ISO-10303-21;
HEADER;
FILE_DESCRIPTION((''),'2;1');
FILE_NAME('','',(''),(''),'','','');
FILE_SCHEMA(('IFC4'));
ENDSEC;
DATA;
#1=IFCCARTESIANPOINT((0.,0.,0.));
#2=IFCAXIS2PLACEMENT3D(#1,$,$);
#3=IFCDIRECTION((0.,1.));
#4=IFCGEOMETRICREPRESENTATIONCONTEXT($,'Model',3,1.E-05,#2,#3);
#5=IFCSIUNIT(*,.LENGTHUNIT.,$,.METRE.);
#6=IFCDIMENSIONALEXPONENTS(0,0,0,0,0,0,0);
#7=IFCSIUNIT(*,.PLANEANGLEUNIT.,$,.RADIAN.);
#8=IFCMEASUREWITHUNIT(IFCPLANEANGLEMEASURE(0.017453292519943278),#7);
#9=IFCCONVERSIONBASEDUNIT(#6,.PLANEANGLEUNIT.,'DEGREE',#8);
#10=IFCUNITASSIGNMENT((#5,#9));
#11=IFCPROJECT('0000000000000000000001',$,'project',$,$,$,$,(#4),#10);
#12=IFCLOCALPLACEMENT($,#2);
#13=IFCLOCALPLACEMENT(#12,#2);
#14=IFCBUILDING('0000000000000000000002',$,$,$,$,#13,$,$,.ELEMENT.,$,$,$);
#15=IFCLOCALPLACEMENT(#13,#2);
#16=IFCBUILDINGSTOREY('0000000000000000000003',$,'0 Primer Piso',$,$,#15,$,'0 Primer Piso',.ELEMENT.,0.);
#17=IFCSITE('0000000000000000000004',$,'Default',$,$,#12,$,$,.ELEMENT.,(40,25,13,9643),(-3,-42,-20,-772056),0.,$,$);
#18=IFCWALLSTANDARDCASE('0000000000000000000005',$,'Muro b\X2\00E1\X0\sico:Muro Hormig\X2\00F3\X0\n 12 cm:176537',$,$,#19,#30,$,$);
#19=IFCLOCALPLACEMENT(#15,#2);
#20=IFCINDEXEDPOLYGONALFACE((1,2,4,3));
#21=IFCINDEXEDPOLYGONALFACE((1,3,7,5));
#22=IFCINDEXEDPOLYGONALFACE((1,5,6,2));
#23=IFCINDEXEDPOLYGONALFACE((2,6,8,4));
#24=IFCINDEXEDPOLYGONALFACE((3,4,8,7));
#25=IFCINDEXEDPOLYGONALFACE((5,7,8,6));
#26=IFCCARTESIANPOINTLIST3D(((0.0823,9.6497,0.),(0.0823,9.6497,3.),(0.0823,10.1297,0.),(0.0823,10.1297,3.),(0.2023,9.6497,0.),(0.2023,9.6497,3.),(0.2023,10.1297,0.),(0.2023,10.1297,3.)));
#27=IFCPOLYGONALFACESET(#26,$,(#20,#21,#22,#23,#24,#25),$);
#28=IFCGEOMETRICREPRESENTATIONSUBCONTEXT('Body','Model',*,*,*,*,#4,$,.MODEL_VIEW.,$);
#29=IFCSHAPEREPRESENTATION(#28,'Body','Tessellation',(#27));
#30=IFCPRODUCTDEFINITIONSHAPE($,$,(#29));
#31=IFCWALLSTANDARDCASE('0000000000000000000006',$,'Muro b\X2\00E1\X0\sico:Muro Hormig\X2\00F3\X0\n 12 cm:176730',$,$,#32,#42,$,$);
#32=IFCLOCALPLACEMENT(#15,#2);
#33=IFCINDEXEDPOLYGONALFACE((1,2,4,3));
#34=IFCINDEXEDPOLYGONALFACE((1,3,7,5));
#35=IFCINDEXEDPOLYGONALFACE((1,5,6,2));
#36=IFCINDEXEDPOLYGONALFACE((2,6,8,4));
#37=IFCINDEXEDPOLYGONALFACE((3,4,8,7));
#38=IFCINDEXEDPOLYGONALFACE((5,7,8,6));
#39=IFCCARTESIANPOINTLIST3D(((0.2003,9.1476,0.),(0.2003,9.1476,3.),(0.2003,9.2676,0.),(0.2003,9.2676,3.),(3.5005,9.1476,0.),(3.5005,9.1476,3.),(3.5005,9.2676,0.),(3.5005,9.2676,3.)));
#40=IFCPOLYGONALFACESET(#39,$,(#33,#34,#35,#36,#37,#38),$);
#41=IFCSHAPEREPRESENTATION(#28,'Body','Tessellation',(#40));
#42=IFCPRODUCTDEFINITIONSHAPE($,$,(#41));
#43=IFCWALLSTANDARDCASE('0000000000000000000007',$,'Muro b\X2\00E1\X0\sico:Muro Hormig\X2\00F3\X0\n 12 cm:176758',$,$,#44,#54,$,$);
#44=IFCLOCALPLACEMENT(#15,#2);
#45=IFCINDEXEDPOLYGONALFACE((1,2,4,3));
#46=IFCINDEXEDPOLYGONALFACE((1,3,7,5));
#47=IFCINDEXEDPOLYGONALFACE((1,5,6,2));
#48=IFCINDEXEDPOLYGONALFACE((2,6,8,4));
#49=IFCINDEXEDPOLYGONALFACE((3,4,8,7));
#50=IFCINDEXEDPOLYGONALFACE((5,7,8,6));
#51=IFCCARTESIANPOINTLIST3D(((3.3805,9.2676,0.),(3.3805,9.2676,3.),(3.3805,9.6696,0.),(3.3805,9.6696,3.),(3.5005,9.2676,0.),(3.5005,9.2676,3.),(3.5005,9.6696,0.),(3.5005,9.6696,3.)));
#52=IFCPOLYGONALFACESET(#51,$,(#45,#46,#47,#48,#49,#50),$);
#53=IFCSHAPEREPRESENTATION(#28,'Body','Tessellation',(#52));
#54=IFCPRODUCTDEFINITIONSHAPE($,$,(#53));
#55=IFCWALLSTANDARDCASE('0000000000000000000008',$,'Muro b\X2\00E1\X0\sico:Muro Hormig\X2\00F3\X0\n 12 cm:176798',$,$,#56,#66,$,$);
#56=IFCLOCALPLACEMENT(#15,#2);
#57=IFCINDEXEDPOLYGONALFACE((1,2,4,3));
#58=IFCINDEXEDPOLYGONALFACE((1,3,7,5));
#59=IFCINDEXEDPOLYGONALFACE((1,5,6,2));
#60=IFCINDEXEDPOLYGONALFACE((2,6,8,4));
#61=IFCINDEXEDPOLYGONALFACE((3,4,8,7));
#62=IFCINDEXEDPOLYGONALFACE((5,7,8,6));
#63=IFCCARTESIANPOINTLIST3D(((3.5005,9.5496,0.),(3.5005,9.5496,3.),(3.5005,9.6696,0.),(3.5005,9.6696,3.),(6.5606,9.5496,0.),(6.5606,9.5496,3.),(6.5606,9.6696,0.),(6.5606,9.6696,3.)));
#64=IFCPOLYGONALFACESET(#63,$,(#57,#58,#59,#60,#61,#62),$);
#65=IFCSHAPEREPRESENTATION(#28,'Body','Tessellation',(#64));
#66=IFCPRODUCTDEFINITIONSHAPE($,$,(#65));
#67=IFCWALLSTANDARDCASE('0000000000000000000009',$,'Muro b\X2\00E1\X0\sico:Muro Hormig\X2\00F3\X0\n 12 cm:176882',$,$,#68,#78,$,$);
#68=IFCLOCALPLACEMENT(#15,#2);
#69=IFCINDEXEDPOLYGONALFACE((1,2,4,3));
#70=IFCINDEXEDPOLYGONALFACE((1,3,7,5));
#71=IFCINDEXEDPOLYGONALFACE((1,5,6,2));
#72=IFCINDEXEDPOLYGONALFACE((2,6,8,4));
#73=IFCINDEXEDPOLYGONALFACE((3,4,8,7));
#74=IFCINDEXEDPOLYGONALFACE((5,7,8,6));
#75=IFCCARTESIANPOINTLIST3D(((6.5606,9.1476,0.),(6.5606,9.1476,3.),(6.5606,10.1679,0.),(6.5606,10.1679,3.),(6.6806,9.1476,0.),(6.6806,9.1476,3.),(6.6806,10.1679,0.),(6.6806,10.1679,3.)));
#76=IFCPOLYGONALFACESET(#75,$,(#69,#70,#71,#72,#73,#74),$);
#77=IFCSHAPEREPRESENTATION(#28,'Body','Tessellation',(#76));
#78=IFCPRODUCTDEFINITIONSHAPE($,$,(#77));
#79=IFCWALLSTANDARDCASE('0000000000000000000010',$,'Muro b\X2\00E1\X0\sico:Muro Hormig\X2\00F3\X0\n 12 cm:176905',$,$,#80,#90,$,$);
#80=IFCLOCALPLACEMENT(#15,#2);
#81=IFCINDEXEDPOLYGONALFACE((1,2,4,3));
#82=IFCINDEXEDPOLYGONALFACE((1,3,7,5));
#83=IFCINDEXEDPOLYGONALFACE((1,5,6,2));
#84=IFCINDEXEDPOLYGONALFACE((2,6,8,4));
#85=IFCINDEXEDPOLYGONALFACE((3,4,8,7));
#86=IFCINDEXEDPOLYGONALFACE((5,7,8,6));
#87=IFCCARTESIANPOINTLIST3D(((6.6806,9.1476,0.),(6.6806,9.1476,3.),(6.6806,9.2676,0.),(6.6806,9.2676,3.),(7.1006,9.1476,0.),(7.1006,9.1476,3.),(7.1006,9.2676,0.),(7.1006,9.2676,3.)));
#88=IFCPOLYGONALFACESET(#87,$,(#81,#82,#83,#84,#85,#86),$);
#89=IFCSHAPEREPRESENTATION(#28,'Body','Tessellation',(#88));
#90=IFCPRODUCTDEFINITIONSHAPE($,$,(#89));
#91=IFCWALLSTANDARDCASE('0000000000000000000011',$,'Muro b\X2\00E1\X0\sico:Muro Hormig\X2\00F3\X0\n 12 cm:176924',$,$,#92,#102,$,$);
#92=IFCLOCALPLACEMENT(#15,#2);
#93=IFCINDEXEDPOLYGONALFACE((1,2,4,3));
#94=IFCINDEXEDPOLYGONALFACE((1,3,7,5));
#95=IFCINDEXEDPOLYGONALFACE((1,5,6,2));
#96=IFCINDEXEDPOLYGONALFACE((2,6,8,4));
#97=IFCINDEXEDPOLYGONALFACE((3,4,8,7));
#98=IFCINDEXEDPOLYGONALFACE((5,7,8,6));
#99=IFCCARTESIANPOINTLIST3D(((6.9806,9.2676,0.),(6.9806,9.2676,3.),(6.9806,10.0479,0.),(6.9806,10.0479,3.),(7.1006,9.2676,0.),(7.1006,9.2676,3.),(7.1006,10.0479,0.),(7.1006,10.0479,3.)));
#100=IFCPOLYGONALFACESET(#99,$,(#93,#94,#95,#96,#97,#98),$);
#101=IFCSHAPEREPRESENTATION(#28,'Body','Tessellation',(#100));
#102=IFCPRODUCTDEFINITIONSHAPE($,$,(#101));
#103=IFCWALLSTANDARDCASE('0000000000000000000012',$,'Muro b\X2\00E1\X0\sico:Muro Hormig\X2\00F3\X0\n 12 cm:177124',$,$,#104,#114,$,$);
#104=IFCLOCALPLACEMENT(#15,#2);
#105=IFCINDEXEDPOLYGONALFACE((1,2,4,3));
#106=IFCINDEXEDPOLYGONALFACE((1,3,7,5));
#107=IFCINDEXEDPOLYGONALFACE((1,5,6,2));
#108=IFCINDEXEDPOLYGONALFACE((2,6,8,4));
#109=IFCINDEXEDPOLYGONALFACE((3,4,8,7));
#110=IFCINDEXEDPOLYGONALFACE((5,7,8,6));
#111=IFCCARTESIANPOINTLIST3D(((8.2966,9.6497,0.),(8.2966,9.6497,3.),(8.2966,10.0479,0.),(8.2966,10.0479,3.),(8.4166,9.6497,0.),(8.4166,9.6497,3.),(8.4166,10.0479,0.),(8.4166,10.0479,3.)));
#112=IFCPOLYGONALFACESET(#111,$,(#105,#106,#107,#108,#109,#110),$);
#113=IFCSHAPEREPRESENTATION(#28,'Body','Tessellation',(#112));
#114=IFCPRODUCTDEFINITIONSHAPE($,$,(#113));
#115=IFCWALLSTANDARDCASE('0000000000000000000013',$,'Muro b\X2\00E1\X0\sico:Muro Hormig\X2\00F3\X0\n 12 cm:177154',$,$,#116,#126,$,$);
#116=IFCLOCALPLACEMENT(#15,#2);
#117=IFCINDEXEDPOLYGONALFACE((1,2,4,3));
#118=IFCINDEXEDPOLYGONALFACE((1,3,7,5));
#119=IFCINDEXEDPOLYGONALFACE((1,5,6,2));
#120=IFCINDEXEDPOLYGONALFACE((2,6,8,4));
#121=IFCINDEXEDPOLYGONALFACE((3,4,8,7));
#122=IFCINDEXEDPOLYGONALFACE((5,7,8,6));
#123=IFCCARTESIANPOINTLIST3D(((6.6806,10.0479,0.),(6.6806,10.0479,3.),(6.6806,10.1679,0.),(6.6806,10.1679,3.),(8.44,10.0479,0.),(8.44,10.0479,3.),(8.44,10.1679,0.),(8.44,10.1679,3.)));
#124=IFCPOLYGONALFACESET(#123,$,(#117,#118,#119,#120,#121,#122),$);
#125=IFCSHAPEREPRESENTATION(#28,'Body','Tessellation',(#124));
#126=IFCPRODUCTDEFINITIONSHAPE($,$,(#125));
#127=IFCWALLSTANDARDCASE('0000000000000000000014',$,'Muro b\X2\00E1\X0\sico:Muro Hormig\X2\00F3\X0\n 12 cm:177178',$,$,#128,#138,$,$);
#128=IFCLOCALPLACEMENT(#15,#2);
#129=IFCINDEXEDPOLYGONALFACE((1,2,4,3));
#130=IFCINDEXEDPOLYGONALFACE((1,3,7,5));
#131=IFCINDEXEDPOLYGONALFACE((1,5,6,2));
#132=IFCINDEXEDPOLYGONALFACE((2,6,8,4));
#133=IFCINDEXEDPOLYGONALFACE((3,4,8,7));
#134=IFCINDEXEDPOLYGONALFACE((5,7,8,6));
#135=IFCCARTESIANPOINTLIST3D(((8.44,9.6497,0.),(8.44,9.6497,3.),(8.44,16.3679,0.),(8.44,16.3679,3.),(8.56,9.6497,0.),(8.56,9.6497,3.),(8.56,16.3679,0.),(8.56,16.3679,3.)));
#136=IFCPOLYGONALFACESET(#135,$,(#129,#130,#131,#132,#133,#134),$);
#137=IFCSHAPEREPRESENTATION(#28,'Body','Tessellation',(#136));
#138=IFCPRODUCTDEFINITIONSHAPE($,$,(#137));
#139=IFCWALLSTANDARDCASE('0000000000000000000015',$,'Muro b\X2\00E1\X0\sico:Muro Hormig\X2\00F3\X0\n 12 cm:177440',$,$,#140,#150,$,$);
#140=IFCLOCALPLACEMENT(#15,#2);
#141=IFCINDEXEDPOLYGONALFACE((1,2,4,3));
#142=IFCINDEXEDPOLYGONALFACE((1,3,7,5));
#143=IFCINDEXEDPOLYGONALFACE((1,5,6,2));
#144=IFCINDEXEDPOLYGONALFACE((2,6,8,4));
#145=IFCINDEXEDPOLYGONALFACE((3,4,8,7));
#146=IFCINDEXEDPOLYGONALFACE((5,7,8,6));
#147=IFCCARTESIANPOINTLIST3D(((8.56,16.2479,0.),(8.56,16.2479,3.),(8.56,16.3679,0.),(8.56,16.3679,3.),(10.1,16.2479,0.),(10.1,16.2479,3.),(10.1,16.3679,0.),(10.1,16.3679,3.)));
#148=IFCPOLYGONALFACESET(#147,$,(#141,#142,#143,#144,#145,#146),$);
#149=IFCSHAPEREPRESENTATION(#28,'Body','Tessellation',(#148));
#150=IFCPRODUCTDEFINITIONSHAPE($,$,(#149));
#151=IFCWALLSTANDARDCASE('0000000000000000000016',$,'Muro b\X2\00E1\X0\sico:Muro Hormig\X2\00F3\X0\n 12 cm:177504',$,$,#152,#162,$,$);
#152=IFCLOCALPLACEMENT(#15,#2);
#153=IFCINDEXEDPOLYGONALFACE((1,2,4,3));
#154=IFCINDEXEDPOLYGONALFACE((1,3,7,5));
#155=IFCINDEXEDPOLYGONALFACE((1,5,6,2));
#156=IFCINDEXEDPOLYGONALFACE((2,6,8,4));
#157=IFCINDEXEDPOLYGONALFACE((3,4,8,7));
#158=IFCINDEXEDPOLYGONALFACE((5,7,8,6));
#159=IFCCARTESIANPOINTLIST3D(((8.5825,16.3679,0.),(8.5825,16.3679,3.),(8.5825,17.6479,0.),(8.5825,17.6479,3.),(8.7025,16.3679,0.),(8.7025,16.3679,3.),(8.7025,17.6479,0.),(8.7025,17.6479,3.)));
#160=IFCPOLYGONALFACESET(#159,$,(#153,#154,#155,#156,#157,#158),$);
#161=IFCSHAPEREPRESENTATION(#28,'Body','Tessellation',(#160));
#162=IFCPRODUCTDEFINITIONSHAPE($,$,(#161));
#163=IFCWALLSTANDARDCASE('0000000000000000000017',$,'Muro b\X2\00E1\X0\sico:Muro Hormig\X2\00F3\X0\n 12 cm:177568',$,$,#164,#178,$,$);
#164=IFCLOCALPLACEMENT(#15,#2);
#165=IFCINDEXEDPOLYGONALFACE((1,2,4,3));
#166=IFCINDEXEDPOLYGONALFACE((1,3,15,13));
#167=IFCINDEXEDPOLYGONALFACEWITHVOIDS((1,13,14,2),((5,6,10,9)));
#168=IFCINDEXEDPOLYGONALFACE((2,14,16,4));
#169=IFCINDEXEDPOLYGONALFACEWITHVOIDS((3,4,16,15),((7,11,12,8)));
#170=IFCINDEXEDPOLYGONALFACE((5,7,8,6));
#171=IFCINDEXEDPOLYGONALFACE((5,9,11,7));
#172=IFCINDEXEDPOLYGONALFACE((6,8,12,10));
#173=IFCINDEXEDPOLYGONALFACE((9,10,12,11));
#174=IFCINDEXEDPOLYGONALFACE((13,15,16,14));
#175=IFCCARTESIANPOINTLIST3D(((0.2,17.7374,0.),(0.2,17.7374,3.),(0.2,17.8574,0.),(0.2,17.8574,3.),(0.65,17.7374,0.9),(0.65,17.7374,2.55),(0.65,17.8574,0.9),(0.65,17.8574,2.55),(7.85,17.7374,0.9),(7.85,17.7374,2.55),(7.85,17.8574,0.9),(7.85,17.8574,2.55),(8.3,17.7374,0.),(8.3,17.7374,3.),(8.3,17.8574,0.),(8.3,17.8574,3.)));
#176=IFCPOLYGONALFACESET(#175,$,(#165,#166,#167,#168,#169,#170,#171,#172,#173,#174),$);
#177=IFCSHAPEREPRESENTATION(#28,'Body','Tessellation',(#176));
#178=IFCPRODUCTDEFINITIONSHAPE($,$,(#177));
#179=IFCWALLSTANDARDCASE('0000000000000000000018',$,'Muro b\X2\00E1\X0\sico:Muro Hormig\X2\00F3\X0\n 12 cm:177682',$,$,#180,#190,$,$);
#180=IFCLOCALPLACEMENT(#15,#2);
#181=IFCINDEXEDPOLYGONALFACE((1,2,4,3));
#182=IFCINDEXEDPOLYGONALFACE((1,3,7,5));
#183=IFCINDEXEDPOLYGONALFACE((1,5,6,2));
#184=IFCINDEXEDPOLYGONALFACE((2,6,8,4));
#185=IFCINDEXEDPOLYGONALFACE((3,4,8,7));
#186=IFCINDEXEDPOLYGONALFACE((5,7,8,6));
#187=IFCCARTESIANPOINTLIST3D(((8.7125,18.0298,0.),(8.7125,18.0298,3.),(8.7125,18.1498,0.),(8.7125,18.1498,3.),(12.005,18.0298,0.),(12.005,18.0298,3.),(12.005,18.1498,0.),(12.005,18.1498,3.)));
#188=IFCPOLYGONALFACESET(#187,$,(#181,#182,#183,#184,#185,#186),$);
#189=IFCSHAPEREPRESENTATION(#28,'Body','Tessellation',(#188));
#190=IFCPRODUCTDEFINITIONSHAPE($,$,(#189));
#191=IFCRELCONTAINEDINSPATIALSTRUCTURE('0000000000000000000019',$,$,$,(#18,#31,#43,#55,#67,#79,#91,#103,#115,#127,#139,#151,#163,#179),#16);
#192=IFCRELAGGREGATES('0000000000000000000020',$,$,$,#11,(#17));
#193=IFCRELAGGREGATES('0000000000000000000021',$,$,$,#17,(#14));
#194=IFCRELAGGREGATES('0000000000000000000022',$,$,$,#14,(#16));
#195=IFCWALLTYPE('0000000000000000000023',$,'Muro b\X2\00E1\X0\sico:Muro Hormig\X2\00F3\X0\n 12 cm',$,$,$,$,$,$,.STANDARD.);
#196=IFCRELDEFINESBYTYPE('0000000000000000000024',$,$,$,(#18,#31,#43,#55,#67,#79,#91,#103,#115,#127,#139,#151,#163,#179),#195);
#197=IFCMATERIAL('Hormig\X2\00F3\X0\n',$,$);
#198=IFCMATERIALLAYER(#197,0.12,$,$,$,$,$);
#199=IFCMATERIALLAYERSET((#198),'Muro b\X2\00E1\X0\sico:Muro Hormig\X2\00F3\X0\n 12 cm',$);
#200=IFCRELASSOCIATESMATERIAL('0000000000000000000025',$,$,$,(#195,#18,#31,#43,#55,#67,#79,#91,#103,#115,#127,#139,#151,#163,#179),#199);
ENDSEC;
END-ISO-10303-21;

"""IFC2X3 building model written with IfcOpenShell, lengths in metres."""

from ifc_helpers import new_model, entity, si_unit, converted_unit, direction, frame, frame_2d, origin, place, context, subcontext, project, spatial, rectangle, extrude, material, layer, layer_set, layer_usage, type_object, element, save


model = new_model("IFC2X3")

# Units and contexts
model_context = context("Model", 3, precision=1e-05, world=origin(), true_north=direction((0.0, 1.0)))
body_context = subcontext(model_context, "Body", "Model", "MODEL_VIEW")
ifc_project = project(units=[si_unit("LENGTHUNIT", "METRE"), converted_unit("PLANEANGLEUNIT", "DEGREE", entity("IfcPlaneAngleMeasure", 0.017453292519943278), si_unit("PLANEANGLEUNIT", "RADIAN"), dimensions=[0, 0, 0, 0, 0, 0, 0])], contexts=[model_context])

# Site, building, storey
site_placement = place(None, origin())
site = spatial("IfcSite", under=ifc_project, at=site_placement, Name="Default", CompositionType="ELEMENT", RefLatitude=(40, 25, 13, 9643), RefLongitude=(-3, -42, -20, -772056), RefElevation=0.0)
building_placement = place(site_placement, origin())
building = spatial("IfcBuilding", under=site, at=building_placement, CompositionType="ELEMENT")
storey_placement = place(building_placement, origin())
storey = spatial("IfcBuildingStorey", under=building, at=storey_placement, Name="0 Primer Piso", LongName="0 Primer Piso", CompositionType="ELEMENT", Elevation=0.0)

# Walls
ifc_material = material(Name="Hormigón")
ifc_layer = layer(ifc_material, 0.12)
ifc_layer_set = layer_set([ifc_layer], Name="Muro básico:Muro Hormigón 12 cm")
ifc_layer_usage_1 = layer_usage(ifc_layer_set, "AXIS2", "NEGATIVE", 0.06)
wall_type = type_object("IfcWallType", Name="Muro básico:Muro Hormigón 12 cm", PredefinedType="STANDARD", material=ifc_layer_set)
wall_1_placement = place(storey_placement, frame((0.1423, 10.1297, 0.0), z_axis=(0.0, 0.0, 1.0), x_axis=(0.0, -1.0, 0.0)))
element("IfcWallStandardCase", 1, at=wall_1_placement, inside=storey, type_object=wall_type, material=ifc_layer_usage_1, Name="Muro básico:Muro Hormigón 12 cm:176537", context=body_context, shape_type="SweptSolid", body=[
    extrude(rectangle(XDim=0.48, YDim=0.12, at=frame_2d((0.24, 0.0), x_axis=(-1.0, 0.0))), origin(), (0.0, 0.0, 1.0), 3.0),
])
ifc_layer_usage_2 = layer_usage(ifc_layer_set, "AXIS2", "NEGATIVE", 0.06)
wall_2_placement = place(storey_placement, frame((0.2003, 9.2076, 0.0)))
element("IfcWallStandardCase", 2, at=wall_2_placement, inside=storey, type_object=wall_type, material=ifc_layer_usage_2, Name="Muro básico:Muro Hormigón 12 cm:176730", context=body_context, shape_type="SweptSolid", body=[
    extrude(rectangle(XDim=3.3001, YDim=0.12, at=frame_2d((1.6501, 0.0), x_axis=(-1.0, 0.0))), origin(), (0.0, 0.0, 1.0), 3.0),
])
ifc_layer_usage_3 = layer_usage(ifc_layer_set, "AXIS2", "NEGATIVE", 0.06)
wall_3_placement = place(storey_placement, frame((3.4405, 9.2676, 0.0), z_axis=(0.0, 0.0, 1.0), x_axis=(0.0, 1.0, 0.0)))
element("IfcWallStandardCase", 3, at=wall_3_placement, inside=storey, type_object=wall_type, material=ifc_layer_usage_3, Name="Muro básico:Muro Hormigón 12 cm:176758", context=body_context, shape_type="SweptSolid", body=[
    extrude(rectangle(XDim=0.402, YDim=0.12, at=frame_2d((0.201, 0.0), x_axis=(-1.0, 0.0))), origin(), (0.0, 0.0, 1.0), 3.0),
])
ifc_layer_usage_4 = layer_usage(ifc_layer_set, "AXIS2", "NEGATIVE", 0.06)
wall_4_placement = place(storey_placement, frame((3.5005, 9.6096, 0.0)))
element("IfcWallStandardCase", 4, at=wall_4_placement, inside=storey, type_object=wall_type, material=ifc_layer_usage_4, Name="Muro básico:Muro Hormigón 12 cm:176798", context=body_context, shape_type="SweptSolid", body=[
    extrude(rectangle(XDim=3.0602, YDim=0.12, at=frame_2d((1.5301, 0.0), x_axis=(-1.0, 0.0))), origin(), (0.0, 0.0, 1.0), 3.0),
])
ifc_layer_usage_5 = layer_usage(ifc_layer_set, "AXIS2", "NEGATIVE", 0.06)
wall_5_placement = place(storey_placement, frame((6.6206, 10.1679, 0.0), z_axis=(0.0, 0.0, 1.0), x_axis=(0.0, -1.0, 0.0)))
element("IfcWallStandardCase", 5, at=wall_5_placement, inside=storey, type_object=wall_type, material=ifc_layer_usage_5, Name="Muro básico:Muro Hormigón 12 cm:176882", context=body_context, shape_type="SweptSolid", body=[
    extrude(rectangle(XDim=1.0203, YDim=0.12, at=frame_2d((0.5101, 0.0), x_axis=(-1.0, 0.0))), origin(), (0.0, 0.0, 1.0), 3.0),
])
ifc_layer_usage_6 = layer_usage(ifc_layer_set, "AXIS2", "NEGATIVE", 0.06)
wall_6_placement = place(storey_placement, frame((6.6806, 9.2076, 0.0)))
element("IfcWallStandardCase", 6, at=wall_6_placement, inside=storey, type_object=wall_type, material=ifc_layer_usage_6, Name="Muro básico:Muro Hormigón 12 cm:176905", context=body_context, shape_type="SweptSolid", body=[
    extrude(rectangle(XDim=0.42, YDim=0.12, at=frame_2d((0.21, 0.0), x_axis=(-1.0, 0.0))), origin(), (0.0, 0.0, 1.0), 3.0),
])
ifc_layer_usage_7 = layer_usage(ifc_layer_set, "AXIS2", "NEGATIVE", 0.06)
wall_7_placement = place(storey_placement, frame((7.0406, 9.2676, 0.0), z_axis=(0.0, 0.0, 1.0), x_axis=(0.0, 1.0, 0.0)))
element("IfcWallStandardCase", 7, at=wall_7_placement, inside=storey, type_object=wall_type, material=ifc_layer_usage_7, Name="Muro básico:Muro Hormigón 12 cm:176924", context=body_context, shape_type="SweptSolid", body=[
    extrude(rectangle(XDim=0.7803, YDim=0.12, at=frame_2d((0.3901, 0.0), x_axis=(-1.0, 0.0))), origin(), (0.0, 0.0, 1.0), 3.0),
])
ifc_layer_usage_8 = layer_usage(ifc_layer_set, "AXIS2", "NEGATIVE", 0.06)
wall_8_placement = place(storey_placement, frame((8.3566, 9.6497, 0.0), z_axis=(0.0, 0.0, 1.0), x_axis=(0.0, 1.0, 0.0)))
element("IfcWallStandardCase", 8, at=wall_8_placement, inside=storey, type_object=wall_type, material=ifc_layer_usage_8, Name="Muro básico:Muro Hormigón 12 cm:177124", context=body_context, shape_type="SweptSolid", body=[
    extrude(rectangle(XDim=0.3981, YDim=0.12, at=frame_2d((0.1991, 0.0), x_axis=(-1.0, 0.0))), origin(), (0.0, 0.0, 1.0), 3.0),
])
ifc_layer_usage_9 = layer_usage(ifc_layer_set, "AXIS2", "NEGATIVE", 0.06)
wall_9_placement = place(storey_placement, frame((6.6806, 10.1079, 0.0)))
element("IfcWallStandardCase", 9, at=wall_9_placement, inside=storey, type_object=wall_type, material=ifc_layer_usage_9, Name="Muro básico:Muro Hormigón 12 cm:177154", context=body_context, shape_type="SweptSolid", body=[
    extrude(rectangle(XDim=1.7594, YDim=0.12, at=frame_2d((0.8797, 0.0), x_axis=(-1.0, 0.0))), origin(), (0.0, 0.0, 1.0), 3.0),
])
ifc_layer_usage_10 = layer_usage(ifc_layer_set, "AXIS2", "NEGATIVE", 0.06)
wall_10_placement = place(storey_placement, frame((8.5, 16.3679, 0.0), z_axis=(0.0, 0.0, 1.0), x_axis=(0.0, -1.0, 0.0)))
element("IfcWallStandardCase", 10, at=wall_10_placement, inside=storey, type_object=wall_type, material=ifc_layer_usage_10, Name="Muro básico:Muro Hormigón 12 cm:177178", context=body_context, shape_type="SweptSolid", body=[
    extrude(rectangle(XDim=6.7181, YDim=0.12, at=frame_2d((3.3591, 0.0), x_axis=(-1.0, 0.0))), origin(), (0.0, 0.0, 1.0), 3.0),
])
ifc_layer_usage_11 = layer_usage(ifc_layer_set, "AXIS2", "NEGATIVE", 0.06)
wall_11_placement = place(storey_placement, frame((8.56, 16.3079, 0.0)))
element("IfcWallStandardCase", 11, at=wall_11_placement, inside=storey, type_object=wall_type, material=ifc_layer_usage_11, Name="Muro básico:Muro Hormigón 12 cm:177440", context=body_context, shape_type="SweptSolid", body=[
    extrude(rectangle(XDim=1.54, YDim=0.12, at=frame_2d((0.77, 0.0), x_axis=(-1.0, 0.0))), origin(), (0.0, 0.0, 1.0), 3.0),
])
ifc_layer_usage_12 = layer_usage(ifc_layer_set, "AXIS2", "NEGATIVE", 0.06)
wall_12_placement = place(storey_placement, frame((8.6425, 16.3679, 0.0), z_axis=(0.0, 0.0, 1.0), x_axis=(0.0, 1.0, 0.0)))
element("IfcWallStandardCase", 12, at=wall_12_placement, inside=storey, type_object=wall_type, material=ifc_layer_usage_12, Name="Muro básico:Muro Hormigón 12 cm:177504", context=body_context, shape_type="SweptSolid", body=[
    extrude(rectangle(XDim=1.28, YDim=0.12, at=frame_2d((0.64, 0.0), x_axis=(-1.0, 0.0))), origin(), (0.0, 0.0, 1.0), 3.0),
])

# Wall, opening
ifc_layer_usage_13 = layer_usage(ifc_layer_set, "AXIS2", "NEGATIVE", 0.06)
wall_13_placement = place(storey_placement, frame((0.2, 17.7974, 0.0)))
wall_13 = element("IfcWallStandardCase", 13, at=wall_13_placement, inside=storey, type_object=wall_type, material=ifc_layer_usage_13, Name="Muro básico:Muro Hormigón 12 cm:177568", context=body_context, shape_type="SweptSolid", body=[
    extrude(rectangle(XDim=8.1, YDim=0.12, at=frame_2d((4.05, 0.0), x_axis=(-1.0, 0.0))), origin(), (0.0, 0.0, 1.0), 3.0),
])
opening_placement = place(wall_13_placement, frame((0.45, -0.06, 0.9)))
element("IfcOpeningElement", 14, at=opening_placement, cuts=wall_13, ObjectType="Opening", context=body_context, shape_type="SweptSolid", body=[
    extrude(rectangle(XDim=1.65, YDim=7.2, at=frame_2d((0.825, 3.6), x_axis=(1.0, 0.0))), frame((0.0, 0.0, 0.0), z_axis=(0.0, 1.0, 0.0), x_axis=(0.0, 0.0, 1.0)), (0.0, 0.0, 1.0), 0.12),
])

# Wall
ifc_layer_usage_14 = layer_usage(ifc_layer_set, "AXIS2", "NEGATIVE", 0.06)
wall_14_placement = place(storey_placement, frame((8.7125, 18.0898, 0.0)))
element("IfcWallStandardCase", 15, at=wall_14_placement, inside=storey, type_object=wall_type, material=ifc_layer_usage_14, Name="Muro básico:Muro Hormigón 12 cm:177682", context=body_context, shape_type="SweptSolid", body=[
    extrude(rectangle(XDim=3.2925, YDim=0.12, at=frame_2d((1.6462, 0.0), x_axis=(-1.0, 0.0))), origin(), (0.0, 0.0, 1.0), 3.0),
])

save(model, "model.ifc")
